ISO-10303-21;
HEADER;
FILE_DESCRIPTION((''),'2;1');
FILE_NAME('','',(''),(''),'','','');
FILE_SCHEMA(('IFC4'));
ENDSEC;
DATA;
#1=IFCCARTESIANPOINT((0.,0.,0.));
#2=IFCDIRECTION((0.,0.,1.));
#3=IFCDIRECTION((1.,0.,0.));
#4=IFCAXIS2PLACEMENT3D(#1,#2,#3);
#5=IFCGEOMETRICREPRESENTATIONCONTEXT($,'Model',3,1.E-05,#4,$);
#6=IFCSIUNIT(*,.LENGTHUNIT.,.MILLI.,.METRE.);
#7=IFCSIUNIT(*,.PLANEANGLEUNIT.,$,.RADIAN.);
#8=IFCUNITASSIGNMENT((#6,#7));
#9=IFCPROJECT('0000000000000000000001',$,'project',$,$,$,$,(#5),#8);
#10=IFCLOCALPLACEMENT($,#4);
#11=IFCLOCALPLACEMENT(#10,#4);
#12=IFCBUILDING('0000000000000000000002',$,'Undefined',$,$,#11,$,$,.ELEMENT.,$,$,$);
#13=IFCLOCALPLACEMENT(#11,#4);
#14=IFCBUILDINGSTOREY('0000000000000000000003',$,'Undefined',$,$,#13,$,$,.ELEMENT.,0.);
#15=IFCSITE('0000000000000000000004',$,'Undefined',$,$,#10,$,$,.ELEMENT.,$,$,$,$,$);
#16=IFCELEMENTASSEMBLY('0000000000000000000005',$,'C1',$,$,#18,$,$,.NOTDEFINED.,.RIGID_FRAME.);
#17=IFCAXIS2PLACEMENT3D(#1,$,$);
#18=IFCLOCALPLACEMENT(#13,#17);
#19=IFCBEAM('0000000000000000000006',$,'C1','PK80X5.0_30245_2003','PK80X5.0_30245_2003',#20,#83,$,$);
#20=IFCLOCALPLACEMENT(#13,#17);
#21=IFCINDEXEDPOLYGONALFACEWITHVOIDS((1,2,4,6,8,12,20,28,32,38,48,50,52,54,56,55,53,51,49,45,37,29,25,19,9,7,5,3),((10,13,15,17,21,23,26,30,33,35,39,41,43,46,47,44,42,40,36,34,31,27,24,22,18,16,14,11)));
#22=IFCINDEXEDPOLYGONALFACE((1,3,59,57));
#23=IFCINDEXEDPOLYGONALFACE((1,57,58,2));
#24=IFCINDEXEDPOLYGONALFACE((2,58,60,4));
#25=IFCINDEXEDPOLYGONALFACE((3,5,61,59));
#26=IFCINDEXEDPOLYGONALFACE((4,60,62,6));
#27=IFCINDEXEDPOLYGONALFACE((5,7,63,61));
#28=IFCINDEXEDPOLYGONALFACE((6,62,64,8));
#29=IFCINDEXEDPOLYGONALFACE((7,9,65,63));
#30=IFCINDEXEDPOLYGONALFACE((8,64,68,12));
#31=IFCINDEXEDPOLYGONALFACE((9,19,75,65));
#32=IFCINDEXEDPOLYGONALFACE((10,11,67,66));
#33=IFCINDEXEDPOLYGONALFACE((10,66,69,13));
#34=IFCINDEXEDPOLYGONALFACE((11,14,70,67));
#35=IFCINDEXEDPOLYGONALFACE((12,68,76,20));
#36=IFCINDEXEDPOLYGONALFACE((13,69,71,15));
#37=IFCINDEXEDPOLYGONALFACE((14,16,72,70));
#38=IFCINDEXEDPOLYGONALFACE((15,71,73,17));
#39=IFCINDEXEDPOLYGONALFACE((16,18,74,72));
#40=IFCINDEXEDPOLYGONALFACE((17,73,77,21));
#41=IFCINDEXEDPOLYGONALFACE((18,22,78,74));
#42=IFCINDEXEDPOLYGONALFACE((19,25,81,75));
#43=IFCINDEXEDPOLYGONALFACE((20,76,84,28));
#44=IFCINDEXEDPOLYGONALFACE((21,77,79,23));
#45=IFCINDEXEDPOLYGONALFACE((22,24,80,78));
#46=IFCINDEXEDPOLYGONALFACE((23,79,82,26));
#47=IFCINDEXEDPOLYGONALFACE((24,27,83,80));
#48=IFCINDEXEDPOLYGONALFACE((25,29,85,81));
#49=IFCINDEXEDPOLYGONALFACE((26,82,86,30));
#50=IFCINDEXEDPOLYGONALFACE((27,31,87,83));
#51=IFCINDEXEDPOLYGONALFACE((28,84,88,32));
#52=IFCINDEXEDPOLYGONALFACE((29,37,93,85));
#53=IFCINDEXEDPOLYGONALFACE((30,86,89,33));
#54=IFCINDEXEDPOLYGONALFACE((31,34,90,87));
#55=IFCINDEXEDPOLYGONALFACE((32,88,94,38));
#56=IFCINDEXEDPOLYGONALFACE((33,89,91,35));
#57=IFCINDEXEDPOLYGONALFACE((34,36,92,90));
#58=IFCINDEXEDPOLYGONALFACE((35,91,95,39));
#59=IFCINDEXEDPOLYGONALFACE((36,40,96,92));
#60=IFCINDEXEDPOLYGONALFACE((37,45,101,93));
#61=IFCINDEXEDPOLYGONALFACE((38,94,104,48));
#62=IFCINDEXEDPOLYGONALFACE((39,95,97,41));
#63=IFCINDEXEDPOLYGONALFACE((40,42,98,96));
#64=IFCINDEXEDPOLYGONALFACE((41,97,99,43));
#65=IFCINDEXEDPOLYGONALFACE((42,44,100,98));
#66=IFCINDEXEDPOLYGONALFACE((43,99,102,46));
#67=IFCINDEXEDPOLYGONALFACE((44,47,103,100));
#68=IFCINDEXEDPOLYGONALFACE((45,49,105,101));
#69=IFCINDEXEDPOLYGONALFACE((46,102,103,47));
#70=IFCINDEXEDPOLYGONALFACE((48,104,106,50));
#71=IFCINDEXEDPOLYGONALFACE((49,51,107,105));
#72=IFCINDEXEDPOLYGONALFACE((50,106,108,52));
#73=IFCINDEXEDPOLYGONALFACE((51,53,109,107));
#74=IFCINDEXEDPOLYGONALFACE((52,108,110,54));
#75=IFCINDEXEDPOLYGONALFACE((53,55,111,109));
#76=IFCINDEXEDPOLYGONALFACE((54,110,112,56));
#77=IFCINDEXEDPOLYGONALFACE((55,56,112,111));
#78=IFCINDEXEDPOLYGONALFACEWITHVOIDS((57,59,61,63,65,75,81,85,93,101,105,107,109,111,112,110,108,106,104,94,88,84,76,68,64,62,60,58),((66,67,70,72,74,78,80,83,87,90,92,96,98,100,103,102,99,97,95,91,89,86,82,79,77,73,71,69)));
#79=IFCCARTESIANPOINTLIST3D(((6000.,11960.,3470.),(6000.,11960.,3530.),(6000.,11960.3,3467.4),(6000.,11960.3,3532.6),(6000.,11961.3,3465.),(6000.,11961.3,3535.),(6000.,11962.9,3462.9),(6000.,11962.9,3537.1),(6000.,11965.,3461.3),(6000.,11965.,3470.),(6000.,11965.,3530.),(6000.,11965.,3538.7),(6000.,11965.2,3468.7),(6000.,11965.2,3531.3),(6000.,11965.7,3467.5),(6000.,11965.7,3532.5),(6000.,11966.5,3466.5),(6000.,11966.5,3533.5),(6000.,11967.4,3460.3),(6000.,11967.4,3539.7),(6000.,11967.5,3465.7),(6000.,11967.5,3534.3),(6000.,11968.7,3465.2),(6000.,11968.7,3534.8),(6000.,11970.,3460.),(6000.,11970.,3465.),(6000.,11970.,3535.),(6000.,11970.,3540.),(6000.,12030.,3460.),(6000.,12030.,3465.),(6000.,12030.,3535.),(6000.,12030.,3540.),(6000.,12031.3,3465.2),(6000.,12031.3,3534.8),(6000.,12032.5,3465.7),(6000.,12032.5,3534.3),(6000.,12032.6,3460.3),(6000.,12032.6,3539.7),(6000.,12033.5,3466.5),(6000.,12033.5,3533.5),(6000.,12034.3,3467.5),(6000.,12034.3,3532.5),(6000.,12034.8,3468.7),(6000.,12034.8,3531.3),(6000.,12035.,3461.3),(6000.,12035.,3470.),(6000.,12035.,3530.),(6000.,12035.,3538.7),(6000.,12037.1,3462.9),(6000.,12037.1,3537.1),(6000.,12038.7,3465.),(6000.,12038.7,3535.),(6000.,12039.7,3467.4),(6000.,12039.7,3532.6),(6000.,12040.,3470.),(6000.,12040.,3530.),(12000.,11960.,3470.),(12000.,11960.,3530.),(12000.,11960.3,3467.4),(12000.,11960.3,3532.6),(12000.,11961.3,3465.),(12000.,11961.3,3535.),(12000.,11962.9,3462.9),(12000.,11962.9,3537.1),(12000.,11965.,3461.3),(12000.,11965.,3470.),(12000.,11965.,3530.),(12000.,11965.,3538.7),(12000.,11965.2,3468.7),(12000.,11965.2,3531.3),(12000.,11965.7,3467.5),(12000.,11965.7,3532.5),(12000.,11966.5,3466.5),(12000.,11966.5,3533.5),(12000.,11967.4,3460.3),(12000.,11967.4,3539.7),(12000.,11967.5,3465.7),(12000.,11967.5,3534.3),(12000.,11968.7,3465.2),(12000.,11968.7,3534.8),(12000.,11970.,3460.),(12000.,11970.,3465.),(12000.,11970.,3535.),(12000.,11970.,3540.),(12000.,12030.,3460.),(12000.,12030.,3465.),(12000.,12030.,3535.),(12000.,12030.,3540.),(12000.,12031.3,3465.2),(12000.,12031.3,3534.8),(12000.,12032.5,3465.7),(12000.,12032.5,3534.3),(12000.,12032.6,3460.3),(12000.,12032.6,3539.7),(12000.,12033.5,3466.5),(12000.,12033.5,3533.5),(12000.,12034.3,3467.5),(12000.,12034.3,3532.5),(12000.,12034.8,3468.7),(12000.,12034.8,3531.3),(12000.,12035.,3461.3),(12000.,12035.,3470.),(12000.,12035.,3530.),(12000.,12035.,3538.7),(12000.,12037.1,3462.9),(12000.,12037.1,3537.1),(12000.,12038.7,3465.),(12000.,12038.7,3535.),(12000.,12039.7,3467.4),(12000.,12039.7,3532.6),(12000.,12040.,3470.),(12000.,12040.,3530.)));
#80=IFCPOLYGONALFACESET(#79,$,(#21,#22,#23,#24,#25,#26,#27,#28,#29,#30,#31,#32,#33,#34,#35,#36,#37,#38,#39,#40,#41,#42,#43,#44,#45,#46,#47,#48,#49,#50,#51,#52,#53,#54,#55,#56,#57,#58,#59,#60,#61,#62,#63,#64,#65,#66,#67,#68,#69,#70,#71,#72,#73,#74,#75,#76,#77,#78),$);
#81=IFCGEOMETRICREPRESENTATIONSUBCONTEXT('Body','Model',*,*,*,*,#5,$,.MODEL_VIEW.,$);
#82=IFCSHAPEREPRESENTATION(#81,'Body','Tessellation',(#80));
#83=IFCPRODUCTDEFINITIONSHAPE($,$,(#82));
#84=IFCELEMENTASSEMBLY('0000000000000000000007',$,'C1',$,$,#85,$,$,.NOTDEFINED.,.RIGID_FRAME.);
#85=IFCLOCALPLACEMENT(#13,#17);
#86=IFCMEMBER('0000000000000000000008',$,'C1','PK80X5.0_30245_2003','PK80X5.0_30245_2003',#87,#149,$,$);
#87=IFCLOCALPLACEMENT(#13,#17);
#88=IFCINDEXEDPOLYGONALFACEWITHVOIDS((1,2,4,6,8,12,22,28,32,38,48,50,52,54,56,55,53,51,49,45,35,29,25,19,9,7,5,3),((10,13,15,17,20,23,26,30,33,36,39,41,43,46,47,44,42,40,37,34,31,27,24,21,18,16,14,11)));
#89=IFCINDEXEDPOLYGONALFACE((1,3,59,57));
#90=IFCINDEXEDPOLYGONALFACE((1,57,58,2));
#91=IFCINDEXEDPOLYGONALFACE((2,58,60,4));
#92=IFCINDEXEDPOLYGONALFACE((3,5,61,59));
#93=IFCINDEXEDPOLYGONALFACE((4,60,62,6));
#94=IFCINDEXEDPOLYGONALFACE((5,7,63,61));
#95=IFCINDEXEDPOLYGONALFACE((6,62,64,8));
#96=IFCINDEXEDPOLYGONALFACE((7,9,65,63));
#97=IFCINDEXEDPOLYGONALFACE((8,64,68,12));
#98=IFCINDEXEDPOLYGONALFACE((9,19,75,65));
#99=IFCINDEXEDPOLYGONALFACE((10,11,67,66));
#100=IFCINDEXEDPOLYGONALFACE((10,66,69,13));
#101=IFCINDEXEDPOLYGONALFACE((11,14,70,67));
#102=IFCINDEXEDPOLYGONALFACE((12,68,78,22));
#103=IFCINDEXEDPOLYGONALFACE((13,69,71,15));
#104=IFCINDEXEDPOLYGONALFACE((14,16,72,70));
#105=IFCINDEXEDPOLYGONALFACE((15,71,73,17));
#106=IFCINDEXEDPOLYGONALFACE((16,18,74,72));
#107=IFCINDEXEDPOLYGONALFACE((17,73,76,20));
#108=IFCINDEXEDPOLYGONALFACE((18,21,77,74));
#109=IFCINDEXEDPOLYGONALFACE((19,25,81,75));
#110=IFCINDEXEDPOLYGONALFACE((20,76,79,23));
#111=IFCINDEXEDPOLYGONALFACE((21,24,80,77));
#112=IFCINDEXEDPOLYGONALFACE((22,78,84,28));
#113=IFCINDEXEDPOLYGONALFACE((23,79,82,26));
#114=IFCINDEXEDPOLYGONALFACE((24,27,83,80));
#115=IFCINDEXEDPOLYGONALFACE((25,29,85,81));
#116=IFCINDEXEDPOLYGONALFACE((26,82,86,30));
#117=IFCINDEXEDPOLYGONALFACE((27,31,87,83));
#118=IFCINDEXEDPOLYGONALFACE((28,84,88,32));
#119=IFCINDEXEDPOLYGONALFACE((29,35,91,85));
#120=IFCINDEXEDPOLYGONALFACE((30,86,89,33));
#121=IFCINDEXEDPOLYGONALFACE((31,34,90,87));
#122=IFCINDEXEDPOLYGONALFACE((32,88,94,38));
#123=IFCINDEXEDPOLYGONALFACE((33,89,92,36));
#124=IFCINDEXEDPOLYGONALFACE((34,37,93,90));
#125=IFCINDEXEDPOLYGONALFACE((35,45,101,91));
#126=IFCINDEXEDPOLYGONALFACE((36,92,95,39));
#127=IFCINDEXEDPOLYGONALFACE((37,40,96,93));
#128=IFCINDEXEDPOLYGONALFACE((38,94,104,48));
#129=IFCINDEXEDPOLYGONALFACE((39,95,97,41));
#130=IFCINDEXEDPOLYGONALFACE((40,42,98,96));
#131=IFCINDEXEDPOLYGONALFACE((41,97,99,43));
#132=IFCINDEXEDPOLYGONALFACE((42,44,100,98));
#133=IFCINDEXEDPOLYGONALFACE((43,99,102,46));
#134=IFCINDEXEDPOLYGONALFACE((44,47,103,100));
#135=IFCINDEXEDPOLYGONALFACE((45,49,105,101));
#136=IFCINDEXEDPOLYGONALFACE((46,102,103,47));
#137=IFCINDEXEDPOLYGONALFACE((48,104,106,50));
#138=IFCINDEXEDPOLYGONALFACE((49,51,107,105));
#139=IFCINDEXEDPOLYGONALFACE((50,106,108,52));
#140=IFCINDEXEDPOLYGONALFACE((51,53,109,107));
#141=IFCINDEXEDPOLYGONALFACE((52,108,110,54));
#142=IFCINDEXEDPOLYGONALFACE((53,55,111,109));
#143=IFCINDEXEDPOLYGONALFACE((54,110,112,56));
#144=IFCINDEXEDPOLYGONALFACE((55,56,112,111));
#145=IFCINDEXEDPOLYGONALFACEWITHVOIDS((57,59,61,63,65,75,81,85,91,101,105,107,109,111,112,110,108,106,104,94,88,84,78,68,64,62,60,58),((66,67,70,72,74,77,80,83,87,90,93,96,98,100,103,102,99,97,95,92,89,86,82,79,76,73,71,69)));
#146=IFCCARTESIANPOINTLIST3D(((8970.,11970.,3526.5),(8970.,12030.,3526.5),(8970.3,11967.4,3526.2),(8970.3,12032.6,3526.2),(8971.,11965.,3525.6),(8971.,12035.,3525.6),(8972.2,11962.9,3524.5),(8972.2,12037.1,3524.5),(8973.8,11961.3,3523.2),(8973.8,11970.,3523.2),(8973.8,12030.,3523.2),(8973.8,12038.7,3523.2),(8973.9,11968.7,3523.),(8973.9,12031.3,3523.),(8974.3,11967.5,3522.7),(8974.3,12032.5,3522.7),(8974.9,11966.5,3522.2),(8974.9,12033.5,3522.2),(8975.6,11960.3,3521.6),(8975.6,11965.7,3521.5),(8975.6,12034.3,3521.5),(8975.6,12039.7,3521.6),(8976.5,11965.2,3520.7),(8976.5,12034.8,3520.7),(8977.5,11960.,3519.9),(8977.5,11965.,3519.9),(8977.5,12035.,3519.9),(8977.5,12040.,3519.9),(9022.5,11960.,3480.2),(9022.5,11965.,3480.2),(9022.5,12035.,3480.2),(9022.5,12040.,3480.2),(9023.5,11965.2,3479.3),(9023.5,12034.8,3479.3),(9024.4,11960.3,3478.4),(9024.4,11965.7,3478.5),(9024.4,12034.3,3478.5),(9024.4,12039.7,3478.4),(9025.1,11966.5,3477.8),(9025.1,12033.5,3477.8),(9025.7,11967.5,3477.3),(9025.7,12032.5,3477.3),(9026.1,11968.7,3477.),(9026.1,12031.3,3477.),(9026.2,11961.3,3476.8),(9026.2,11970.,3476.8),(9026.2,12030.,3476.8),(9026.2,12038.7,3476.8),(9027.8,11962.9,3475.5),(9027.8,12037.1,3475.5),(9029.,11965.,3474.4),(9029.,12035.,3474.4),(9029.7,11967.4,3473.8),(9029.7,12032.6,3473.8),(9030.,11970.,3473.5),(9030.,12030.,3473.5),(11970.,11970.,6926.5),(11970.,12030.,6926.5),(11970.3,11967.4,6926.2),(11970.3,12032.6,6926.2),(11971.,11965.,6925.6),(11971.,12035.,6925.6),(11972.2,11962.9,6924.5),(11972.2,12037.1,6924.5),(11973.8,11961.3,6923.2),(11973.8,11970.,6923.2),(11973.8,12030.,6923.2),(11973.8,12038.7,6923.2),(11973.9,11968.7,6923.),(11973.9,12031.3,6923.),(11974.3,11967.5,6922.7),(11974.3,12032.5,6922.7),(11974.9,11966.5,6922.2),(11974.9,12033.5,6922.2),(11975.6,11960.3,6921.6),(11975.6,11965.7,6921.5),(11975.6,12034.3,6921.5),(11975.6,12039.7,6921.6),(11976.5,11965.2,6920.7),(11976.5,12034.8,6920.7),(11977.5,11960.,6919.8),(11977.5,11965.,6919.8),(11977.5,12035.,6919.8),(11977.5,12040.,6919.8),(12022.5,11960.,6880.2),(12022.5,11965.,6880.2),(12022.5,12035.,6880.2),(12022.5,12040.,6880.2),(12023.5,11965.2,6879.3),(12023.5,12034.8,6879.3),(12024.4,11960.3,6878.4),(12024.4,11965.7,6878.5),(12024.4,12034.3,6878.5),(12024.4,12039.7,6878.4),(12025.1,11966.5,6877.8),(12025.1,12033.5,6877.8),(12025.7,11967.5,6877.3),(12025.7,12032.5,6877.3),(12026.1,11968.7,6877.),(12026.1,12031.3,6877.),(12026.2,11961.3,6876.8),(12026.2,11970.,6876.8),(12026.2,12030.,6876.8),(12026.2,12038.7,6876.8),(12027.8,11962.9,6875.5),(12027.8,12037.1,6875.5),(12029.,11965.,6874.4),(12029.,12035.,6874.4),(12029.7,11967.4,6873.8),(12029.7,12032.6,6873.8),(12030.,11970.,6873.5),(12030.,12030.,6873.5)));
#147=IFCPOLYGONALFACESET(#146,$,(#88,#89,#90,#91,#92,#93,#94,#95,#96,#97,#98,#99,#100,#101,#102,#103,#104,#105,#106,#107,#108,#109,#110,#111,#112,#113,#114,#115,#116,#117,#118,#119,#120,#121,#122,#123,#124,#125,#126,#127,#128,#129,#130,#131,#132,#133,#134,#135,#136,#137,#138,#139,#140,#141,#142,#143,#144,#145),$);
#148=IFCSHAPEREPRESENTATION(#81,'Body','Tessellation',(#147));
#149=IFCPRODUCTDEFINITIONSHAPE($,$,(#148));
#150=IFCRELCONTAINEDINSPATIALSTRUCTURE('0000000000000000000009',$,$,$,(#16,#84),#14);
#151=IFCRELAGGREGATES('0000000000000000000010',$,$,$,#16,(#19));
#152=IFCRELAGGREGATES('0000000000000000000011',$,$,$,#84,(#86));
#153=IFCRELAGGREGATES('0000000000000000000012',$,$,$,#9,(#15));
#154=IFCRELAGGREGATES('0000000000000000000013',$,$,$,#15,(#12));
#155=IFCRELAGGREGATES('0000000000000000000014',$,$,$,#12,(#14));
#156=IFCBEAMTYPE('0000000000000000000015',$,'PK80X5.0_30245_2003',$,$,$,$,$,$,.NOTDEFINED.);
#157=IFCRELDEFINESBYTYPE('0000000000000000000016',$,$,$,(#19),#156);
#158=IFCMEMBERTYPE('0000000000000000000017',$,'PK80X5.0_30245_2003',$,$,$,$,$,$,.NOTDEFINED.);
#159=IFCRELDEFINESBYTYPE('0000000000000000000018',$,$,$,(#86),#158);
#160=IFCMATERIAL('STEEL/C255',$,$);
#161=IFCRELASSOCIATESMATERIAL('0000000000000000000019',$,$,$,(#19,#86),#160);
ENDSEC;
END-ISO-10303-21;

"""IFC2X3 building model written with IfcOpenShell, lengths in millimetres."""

from ifc_helpers import new_model, si_unit, frame, origin_with_axes, origin_2d_with_axis, place, context, subcontext, project, spatial, hollow_rectangle, extrude, material, type_object, element, aggregate, save


model = new_model("IFC2X3")

# Units and contexts
model_context = context("Model", 3, precision=1e-05, world=origin_with_axes())
body_context = subcontext(model_context, "Body", "Model", "MODEL_VIEW")
ifc_project = project(units=[si_unit("LENGTHUNIT", "METRE", prefix="MILLI"), si_unit("PLANEANGLEUNIT", "RADIAN")], contexts=[model_context])

# Site, building, storey
site_placement = place(None, origin_with_axes())
site = spatial("IfcSite", under=ifc_project, at=site_placement, Name="Undefined", CompositionType="ELEMENT")
building_placement = place(site_placement, origin_with_axes())
building = spatial("IfcBuilding", under=site, at=building_placement, Name="Undefined", CompositionType="ELEMENT")
storey_placement = place(building_placement, origin_with_axes())
storey = spatial("IfcBuildingStorey", under=building, at=storey_placement, Name="Undefined", CompositionType="ELEMENT", Elevation=0.0)

# Element assembly, beam
ifc_material_1 = material(Name="STEEL/C255")
beam_type_1 = type_object("IfcBeamType", Name="PK80X5.0_30245_2003", PredefinedType="NOTDEFINED")
assembly_1_placement = place(storey_placement, origin_with_axes())
assembly_1 = element("IfcElementAssembly", 1, at=assembly_1_placement, inside=storey, Name="C1", AssemblyPlace="NOTDEFINED", PredefinedType="RIGID_FRAME")
beam_1_placement = place(assembly_1_placement, frame((6000.0, 12000.0, 3500.0), z_axis=(0.0, 0.0, -1.0), x_axis=(1.0, 0.0, 0.0)))
beam_1 = element("IfcBeam", 2, at=beam_1_placement, type_object=beam_type_1, material=ifc_material_1, Name="C1", Description="PK80X5.0_30245_2003", ObjectType="PK80X5.0_30245_2003", context=body_context, shape_type="SweptSolid", body=[
    extrude(hollow_rectangle(XDim=80.0, YDim=80.0, WallThickness=5.0, InnerFilletRadius=5.0, OuterFilletRadius=10.0, at=origin_2d_with_axis()), frame((6000.0, 0.0, 0.0), z_axis=(-1.0, 0.0, 0.0), x_axis=(0.0, -1.0, 0.0)), (0.0, 0.0, 1.0), 6000.0),
])
aggregate(assembly_1, [beam_1])

# Element assembly, member
assembly_2_placement = place(storey_placement, origin_with_axes())
assembly_2 = element("IfcElementAssembly", 3, at=assembly_2_placement, inside=storey, Name="C1", AssemblyPlace="NOTDEFINED", PredefinedType="RIGID_FRAME")
member_type = type_object("IfcMemberType", Name="PK80X5.0_30245_2003", PredefinedType="NOTDEFINED")
member_1_placement = place(assembly_2_placement, frame((9000.0, 12000.0, 3500.0), z_axis=(0.749838, 0.0, -0.661622), x_axis=(0.661622, 0.0, 0.749838)))
member_1 = element("IfcMember", 4, at=member_1_placement, type_object=member_type, material=ifc_material_1, Name="C1", Description="PK80X5.0_30245_2003", ObjectType="PK80X5.0_30245_2003", context=body_context, shape_type="SweptSolid", body=[
    extrude(hollow_rectangle(XDim=80.0, YDim=80.0, WallThickness=5.0, InnerFilletRadius=5.0, OuterFilletRadius=10.0, at=origin_2d_with_axis()), frame((4534.3, 0.0, 0.0), z_axis=(-1.0, 0.0, 0.0), x_axis=(0.0, -1.0, 0.0)), (0.0, 0.0, 1.0), 4534.3),
])
aggregate(assembly_2, [member_1])

save(model, "model.ifc")
